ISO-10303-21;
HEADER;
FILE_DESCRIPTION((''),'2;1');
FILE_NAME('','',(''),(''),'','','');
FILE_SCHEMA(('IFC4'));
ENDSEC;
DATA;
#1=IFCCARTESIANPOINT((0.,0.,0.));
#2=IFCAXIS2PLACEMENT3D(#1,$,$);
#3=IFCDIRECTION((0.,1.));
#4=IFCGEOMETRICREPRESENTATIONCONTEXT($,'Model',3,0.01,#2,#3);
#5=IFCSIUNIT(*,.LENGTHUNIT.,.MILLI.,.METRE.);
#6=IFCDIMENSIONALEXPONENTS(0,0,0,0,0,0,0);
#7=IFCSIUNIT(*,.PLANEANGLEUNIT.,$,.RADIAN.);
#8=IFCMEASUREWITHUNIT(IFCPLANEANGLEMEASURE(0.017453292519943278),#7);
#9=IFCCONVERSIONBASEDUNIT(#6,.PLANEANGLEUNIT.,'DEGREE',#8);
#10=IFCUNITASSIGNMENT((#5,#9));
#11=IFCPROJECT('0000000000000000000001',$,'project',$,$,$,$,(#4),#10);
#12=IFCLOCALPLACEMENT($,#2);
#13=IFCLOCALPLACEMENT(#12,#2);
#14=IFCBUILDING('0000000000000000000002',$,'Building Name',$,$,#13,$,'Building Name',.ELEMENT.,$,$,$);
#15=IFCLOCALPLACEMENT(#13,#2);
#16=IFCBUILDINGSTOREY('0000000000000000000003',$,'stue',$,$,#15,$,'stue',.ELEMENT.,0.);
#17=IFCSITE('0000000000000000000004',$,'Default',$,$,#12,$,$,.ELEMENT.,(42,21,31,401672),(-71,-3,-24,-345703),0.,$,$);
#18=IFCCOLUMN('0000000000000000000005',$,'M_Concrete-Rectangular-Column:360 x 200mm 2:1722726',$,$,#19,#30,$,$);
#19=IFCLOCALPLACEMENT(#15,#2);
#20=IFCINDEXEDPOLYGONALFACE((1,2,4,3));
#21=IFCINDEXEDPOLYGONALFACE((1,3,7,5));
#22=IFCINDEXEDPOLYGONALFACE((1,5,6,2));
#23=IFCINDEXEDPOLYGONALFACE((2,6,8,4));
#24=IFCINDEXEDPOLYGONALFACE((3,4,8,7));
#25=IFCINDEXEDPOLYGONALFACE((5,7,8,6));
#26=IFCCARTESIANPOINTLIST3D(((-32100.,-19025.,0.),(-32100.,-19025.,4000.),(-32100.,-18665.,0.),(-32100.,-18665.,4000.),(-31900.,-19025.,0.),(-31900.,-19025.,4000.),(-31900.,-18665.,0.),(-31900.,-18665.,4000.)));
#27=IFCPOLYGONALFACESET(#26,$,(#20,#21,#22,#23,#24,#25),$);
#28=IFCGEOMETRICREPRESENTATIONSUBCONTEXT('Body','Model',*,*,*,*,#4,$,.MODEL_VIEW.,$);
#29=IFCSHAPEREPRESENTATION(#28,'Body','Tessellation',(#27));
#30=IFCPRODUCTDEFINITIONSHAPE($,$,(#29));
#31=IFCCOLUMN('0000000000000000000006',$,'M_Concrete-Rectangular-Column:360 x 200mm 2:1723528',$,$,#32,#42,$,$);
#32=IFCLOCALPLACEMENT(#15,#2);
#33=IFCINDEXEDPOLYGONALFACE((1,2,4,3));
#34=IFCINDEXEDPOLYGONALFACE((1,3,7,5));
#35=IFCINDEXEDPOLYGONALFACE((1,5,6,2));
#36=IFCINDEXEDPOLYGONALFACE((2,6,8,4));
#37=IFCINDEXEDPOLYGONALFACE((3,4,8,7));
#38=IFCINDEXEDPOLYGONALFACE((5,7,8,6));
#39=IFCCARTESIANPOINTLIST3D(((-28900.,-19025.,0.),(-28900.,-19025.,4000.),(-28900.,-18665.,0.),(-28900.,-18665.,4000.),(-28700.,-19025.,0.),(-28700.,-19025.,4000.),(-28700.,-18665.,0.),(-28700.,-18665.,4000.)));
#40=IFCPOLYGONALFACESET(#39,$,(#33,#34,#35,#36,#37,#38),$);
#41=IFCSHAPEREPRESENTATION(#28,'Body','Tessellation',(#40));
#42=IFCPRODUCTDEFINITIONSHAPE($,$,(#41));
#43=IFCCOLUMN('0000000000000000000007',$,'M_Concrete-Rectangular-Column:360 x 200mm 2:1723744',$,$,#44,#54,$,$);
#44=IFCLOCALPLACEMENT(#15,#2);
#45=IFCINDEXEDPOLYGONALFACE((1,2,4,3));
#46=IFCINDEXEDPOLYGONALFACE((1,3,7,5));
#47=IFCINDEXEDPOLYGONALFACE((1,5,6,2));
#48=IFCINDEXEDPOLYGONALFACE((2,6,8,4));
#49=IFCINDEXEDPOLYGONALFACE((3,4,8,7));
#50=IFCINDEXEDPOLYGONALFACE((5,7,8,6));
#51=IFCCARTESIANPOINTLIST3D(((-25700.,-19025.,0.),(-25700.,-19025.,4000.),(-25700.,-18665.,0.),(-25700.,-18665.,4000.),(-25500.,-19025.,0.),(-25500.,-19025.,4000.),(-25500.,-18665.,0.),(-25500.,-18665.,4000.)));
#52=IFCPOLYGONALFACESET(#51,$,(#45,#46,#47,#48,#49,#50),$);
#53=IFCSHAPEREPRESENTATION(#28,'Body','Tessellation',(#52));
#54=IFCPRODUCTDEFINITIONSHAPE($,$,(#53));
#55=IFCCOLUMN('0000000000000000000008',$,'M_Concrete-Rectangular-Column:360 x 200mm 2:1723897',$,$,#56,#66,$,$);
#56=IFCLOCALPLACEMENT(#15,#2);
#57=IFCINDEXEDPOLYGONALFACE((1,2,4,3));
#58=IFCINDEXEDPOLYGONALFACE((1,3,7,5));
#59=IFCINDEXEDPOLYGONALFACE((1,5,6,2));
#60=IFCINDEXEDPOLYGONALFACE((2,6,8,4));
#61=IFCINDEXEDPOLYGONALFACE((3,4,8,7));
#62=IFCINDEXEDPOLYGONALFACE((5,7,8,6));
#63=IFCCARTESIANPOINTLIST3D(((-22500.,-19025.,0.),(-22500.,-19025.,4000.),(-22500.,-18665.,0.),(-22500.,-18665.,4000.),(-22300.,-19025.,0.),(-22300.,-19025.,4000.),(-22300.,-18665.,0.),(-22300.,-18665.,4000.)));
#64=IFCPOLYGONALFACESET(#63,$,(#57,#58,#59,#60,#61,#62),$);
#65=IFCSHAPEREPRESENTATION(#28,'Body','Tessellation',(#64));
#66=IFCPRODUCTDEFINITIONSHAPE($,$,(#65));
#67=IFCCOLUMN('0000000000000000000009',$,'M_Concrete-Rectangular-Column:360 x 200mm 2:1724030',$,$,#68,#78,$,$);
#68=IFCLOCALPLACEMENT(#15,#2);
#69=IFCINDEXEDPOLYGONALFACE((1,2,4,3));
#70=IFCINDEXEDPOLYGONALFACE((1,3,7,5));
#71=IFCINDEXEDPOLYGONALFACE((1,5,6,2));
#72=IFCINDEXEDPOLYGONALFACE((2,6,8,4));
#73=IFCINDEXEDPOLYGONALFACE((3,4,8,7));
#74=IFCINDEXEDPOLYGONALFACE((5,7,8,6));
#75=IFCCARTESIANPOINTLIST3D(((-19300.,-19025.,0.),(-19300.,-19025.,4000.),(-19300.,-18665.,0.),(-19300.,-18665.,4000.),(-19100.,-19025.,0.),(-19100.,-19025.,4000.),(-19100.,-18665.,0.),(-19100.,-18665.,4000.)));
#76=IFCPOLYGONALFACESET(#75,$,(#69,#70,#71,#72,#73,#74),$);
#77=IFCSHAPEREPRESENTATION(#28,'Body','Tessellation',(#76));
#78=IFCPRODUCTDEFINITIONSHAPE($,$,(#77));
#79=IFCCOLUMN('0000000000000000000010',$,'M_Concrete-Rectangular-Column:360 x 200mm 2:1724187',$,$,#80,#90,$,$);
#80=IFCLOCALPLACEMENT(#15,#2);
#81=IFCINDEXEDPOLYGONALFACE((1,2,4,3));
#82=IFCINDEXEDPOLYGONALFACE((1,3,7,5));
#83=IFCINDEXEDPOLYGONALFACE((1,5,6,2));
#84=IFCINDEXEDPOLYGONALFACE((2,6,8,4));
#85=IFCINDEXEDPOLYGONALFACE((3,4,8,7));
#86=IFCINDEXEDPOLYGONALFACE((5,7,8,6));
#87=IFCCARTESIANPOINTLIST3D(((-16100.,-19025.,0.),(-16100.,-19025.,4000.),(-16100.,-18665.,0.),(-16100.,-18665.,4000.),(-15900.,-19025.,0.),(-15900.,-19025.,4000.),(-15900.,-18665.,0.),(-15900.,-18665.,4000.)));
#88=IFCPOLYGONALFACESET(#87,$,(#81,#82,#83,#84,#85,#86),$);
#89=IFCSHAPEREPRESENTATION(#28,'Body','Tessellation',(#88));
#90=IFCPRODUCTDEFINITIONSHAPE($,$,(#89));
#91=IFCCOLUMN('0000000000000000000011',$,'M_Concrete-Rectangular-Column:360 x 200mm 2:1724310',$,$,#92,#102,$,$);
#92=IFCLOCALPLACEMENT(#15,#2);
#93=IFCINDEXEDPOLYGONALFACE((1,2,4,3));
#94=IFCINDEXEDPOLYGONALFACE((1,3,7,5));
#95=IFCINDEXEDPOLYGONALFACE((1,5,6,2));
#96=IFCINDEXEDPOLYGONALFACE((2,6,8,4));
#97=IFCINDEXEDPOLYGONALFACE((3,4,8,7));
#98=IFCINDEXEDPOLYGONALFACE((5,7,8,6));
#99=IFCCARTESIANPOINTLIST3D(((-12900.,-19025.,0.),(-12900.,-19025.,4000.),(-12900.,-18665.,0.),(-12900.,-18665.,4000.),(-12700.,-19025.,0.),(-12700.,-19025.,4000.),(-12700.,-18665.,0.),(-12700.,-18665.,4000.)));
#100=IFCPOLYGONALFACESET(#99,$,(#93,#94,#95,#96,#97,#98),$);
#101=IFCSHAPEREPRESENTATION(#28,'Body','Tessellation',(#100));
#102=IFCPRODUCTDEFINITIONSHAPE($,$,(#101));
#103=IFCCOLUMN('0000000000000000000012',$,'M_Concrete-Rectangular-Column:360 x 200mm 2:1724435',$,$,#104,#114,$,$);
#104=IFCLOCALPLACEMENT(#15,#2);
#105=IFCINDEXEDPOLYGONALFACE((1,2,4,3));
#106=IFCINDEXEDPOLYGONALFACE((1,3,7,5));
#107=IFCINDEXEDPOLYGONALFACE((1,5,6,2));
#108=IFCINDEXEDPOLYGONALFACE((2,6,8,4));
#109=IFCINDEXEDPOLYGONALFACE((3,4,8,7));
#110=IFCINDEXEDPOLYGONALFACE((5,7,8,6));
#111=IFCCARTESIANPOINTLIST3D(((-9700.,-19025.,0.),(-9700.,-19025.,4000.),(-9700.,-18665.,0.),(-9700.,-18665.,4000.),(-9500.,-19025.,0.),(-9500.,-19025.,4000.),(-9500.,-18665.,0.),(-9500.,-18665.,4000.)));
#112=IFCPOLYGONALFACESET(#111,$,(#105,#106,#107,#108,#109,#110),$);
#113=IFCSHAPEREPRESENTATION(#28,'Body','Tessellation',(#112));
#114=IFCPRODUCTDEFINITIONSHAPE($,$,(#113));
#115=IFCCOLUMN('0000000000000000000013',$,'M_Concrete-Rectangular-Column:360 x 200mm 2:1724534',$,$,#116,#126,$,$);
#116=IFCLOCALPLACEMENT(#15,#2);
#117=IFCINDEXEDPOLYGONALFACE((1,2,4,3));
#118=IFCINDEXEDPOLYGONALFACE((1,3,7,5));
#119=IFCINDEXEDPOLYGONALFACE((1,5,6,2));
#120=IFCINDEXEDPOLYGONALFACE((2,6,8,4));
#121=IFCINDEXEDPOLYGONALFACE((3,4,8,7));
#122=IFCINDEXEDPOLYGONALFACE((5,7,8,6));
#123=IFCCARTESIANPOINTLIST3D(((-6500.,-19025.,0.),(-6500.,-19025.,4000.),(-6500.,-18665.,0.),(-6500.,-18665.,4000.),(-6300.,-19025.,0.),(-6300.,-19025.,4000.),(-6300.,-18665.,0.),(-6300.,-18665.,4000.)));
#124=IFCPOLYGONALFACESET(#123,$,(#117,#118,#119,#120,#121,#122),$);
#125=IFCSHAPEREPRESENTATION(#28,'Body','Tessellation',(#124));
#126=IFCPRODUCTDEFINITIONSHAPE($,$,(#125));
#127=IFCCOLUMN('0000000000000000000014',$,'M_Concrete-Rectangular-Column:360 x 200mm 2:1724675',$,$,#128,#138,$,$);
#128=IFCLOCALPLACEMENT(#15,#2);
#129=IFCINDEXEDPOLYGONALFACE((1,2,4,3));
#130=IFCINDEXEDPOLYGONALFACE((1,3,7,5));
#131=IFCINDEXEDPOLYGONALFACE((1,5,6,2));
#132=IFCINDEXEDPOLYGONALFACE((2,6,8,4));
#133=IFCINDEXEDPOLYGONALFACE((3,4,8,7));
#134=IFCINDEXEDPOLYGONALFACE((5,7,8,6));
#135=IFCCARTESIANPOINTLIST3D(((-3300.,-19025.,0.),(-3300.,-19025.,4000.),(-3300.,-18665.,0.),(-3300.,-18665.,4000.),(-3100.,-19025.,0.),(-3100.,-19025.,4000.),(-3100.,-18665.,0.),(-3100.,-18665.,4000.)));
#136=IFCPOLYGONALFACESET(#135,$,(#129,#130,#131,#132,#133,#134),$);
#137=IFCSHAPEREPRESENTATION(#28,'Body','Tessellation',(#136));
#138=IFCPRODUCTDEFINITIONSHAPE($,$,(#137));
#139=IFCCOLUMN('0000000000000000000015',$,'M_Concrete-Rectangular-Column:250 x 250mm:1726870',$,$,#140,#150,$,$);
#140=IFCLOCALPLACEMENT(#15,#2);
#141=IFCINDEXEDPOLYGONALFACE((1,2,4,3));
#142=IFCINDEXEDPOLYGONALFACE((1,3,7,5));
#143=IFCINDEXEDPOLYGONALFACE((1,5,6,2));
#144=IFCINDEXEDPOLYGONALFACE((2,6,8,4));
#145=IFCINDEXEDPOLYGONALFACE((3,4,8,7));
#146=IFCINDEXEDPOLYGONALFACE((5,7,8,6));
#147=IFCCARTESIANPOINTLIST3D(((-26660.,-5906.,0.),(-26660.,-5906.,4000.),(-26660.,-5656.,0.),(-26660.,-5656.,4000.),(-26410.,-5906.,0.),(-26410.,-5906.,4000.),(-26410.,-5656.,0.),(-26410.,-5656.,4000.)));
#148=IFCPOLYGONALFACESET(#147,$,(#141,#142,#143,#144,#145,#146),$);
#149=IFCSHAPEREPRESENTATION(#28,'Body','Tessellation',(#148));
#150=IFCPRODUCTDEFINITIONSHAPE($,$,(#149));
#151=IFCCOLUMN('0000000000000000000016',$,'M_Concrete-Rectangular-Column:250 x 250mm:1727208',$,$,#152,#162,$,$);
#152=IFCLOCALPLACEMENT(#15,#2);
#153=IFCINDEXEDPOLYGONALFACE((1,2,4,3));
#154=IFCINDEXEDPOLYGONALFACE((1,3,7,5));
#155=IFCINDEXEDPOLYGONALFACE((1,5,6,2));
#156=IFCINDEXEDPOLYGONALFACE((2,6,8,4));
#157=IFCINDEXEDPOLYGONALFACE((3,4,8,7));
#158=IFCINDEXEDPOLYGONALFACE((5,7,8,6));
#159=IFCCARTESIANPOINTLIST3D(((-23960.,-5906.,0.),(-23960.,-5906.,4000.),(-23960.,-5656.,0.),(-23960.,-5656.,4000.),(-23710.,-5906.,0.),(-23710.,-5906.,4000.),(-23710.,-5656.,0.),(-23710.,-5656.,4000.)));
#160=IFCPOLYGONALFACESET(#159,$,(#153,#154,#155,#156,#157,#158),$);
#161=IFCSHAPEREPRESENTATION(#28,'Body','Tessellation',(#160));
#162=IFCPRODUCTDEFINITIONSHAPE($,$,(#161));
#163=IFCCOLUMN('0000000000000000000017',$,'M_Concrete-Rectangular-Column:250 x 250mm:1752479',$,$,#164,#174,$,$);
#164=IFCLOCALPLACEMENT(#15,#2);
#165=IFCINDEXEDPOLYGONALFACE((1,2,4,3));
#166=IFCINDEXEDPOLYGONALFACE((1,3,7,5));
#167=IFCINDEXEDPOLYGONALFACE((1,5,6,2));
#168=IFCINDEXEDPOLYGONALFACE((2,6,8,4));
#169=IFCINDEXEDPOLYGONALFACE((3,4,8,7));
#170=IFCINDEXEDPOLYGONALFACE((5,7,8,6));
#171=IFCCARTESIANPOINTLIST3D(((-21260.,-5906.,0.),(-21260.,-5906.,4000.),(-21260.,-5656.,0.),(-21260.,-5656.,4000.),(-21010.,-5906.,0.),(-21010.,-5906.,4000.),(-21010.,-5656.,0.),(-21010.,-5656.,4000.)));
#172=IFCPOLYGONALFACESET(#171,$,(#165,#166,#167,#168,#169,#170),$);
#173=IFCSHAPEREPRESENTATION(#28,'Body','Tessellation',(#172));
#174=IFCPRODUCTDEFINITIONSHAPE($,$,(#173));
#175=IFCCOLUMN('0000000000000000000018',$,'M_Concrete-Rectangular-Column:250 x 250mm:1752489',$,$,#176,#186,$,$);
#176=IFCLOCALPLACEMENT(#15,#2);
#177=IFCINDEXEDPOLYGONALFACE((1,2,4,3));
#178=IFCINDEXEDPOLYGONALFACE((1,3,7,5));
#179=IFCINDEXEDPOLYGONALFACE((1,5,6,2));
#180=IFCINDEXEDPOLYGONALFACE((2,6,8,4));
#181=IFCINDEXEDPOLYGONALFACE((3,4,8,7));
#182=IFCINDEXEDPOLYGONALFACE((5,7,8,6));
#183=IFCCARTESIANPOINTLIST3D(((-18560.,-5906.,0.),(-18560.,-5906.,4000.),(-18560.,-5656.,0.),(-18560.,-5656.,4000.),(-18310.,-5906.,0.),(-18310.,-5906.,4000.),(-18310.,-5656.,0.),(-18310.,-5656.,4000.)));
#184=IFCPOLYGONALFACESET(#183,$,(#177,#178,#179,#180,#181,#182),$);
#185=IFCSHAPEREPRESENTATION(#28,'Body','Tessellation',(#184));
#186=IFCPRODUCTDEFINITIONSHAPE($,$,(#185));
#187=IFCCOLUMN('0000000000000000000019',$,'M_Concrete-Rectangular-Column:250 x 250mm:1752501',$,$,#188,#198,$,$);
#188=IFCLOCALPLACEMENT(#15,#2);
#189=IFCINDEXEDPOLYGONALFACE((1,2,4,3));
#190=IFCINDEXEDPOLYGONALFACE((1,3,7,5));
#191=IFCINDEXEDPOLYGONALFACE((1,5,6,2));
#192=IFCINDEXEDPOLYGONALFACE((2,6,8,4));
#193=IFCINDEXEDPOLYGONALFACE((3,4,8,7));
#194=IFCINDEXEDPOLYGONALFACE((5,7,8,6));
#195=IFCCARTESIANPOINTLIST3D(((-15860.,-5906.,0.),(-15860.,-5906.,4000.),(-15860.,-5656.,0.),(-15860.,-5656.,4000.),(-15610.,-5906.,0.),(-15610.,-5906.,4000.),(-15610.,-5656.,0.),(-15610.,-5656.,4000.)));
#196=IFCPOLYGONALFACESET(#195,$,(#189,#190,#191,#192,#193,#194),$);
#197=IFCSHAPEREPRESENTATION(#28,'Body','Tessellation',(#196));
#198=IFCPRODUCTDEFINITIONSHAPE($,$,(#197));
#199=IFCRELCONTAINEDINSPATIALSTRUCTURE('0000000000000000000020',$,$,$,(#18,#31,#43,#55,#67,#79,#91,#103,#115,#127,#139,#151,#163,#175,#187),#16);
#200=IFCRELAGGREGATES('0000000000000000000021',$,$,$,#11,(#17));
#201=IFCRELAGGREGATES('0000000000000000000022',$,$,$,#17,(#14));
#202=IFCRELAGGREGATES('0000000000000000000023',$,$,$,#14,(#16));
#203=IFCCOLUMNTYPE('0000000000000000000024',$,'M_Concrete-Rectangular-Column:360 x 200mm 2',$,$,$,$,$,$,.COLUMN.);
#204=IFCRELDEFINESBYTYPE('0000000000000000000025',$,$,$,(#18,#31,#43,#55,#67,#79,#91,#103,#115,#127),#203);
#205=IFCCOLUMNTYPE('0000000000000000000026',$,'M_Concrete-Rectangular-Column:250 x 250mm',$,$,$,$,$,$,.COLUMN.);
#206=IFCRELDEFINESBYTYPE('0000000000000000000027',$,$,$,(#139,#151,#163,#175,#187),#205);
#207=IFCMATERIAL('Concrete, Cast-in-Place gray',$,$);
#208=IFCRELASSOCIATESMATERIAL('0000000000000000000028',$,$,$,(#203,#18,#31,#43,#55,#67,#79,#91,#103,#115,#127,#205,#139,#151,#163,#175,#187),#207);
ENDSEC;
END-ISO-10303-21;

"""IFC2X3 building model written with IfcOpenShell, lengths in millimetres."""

from ifc_helpers import new_model, entity, si_unit, converted_unit, direction, frame, origin, origin_2d_with_axis, place, context, subcontext, project, spatial, rectangle, extrude, source, transform, mapped, material, type_object, type_shapes, element, save


model = new_model("IFC2X3")

# Units and contexts
model_context = context("Model", 3, precision=0.01, world=origin(), true_north=direction((0.0, 1.0)))
body_context = subcontext(model_context, "Body", "Model", "MODEL_VIEW")
ifc_project = project(units=[si_unit("LENGTHUNIT", "METRE", prefix="MILLI"), converted_unit("PLANEANGLEUNIT", "DEGREE", entity("IfcPlaneAngleMeasure", 0.017453292519943278), si_unit("PLANEANGLEUNIT", "RADIAN"), dimensions=[0, 0, 0, 0, 0, 0, 0])], contexts=[model_context])

# Site, building, storey
site_placement = place(None, origin())
site = spatial("IfcSite", under=ifc_project, at=site_placement, Name="Default", CompositionType="ELEMENT", RefLatitude=(42, 21, 31, 401672), RefLongitude=(-71, -3, -24, -345703), RefElevation=0.0)
building_placement = place(site_placement, origin())
building = spatial("IfcBuilding", under=site, at=building_placement, Name="Building Name", LongName="Building Name", CompositionType="ELEMENT")
storey_placement = place(building_placement, origin())
storey = spatial("IfcBuildingStorey", under=building, at=storey_placement, Name="stue", LongName="stue", CompositionType="ELEMENT", Elevation=0.0)

# Columns
ifc_material_1 = material(Name="Concrete, Cast-in-Place gray")
column_type_1 = type_object("IfcColumnType", Name="M_Concrete-Rectangular-Column:360 x 200mm 2", PredefinedType="COLUMN", material=ifc_material_1)
shared_shape_1 = source(origin(), body_context, "Body", "SweptSolid", [
    extrude(rectangle(XDim=200.0, YDim=360.0, at=origin_2d_with_axis()), frame((0.0, 0.0, 0.0), z_axis=(0.0, 0.0, 1.0), x_axis=(-1.0, 0.0, 0.0)), (0.0, 0.0, 1.0), 4000.0),
])
type_shapes(column_type_1, [shared_shape_1])
for number, where, name in (
    (1, (-32000.0, -18845.0, 0.0), "M_Concrete-Rectangular-Column:360 x 200mm 2:1722726"),
    (2, (-28800.0, -18845.0, 0.0), "M_Concrete-Rectangular-Column:360 x 200mm 2:1723528"),
    (3, (-25600.0, -18845.0, 0.0), "M_Concrete-Rectangular-Column:360 x 200mm 2:1723744"),
    (4, (-22400.0, -18845.0, 0.0), "M_Concrete-Rectangular-Column:360 x 200mm 2:1723897"),
    (5, (-19200.0, -18845.0, 0.0), "M_Concrete-Rectangular-Column:360 x 200mm 2:1724030"),
    (6, (-16000.0, -18845.0, 0.0), "M_Concrete-Rectangular-Column:360 x 200mm 2:1724187"),
    (7, (-12800.0, -18845.0, 0.0), "M_Concrete-Rectangular-Column:360 x 200mm 2:1724310"),
    (8, (-9600.0, -18845.0, 0.0), "M_Concrete-Rectangular-Column:360 x 200mm 2:1724435"),
    (9, (-6400.0, -18845.0, 0.0), "M_Concrete-Rectangular-Column:360 x 200mm 2:1724534"),
    (10, (-3200.0, -18845.0, 0.0), "M_Concrete-Rectangular-Column:360 x 200mm 2:1724675"),
):
    element("IfcColumn", number, at=place(storey_placement, frame(where)), inside=storey, type_object=column_type_1, material=ifc_material_1, Name=name, context=body_context, shape_type="MappedRepresentation", body=[
        mapped(shared_shape_1, transform((0.0, 0.0, 0.0), scale=1.0)),
    ])
column_type_2 = type_object("IfcColumnType", Name="M_Concrete-Rectangular-Column:250 x 250mm", PredefinedType="COLUMN", material=ifc_material_1)
shared_shape_2 = source(origin(), body_context, "Body", "SweptSolid", [
    extrude(rectangle(XDim=250.0, YDim=250.0, at=origin_2d_with_axis()), frame((0.0, 0.0, 0.0), z_axis=(0.0, 0.0, 1.0), x_axis=(-1.0, 0.0, 0.0)), (0.0, 0.0, 1.0), 4000.0),
])
type_shapes(column_type_2, [shared_shape_2])
for number, where, name in (
    (11, (-26535.0, -5781.0, 0.0), "M_Concrete-Rectangular-Column:250 x 250mm:1726870"),
    (12, (-23835.0, -5781.0, 0.0), "M_Concrete-Rectangular-Column:250 x 250mm:1727208"),
    (13, (-21135.0, -5781.0, 0.0), "M_Concrete-Rectangular-Column:250 x 250mm:1752479"),
    (14, (-18435.0, -5781.0, 0.0), "M_Concrete-Rectangular-Column:250 x 250mm:1752489"),
    (15, (-15735.0, -5781.0, 0.0), "M_Concrete-Rectangular-Column:250 x 250mm:1752501"),
):
    element("IfcColumn", number, at=place(storey_placement, frame(where)), inside=storey, type_object=column_type_2, material=ifc_material_1, Name=name, context=body_context, shape_type="MappedRepresentation", body=[
        mapped(shared_shape_2, transform((0.0, 0.0, 0.0), scale=1.0)),
    ])

save(model, "model.ifc")
